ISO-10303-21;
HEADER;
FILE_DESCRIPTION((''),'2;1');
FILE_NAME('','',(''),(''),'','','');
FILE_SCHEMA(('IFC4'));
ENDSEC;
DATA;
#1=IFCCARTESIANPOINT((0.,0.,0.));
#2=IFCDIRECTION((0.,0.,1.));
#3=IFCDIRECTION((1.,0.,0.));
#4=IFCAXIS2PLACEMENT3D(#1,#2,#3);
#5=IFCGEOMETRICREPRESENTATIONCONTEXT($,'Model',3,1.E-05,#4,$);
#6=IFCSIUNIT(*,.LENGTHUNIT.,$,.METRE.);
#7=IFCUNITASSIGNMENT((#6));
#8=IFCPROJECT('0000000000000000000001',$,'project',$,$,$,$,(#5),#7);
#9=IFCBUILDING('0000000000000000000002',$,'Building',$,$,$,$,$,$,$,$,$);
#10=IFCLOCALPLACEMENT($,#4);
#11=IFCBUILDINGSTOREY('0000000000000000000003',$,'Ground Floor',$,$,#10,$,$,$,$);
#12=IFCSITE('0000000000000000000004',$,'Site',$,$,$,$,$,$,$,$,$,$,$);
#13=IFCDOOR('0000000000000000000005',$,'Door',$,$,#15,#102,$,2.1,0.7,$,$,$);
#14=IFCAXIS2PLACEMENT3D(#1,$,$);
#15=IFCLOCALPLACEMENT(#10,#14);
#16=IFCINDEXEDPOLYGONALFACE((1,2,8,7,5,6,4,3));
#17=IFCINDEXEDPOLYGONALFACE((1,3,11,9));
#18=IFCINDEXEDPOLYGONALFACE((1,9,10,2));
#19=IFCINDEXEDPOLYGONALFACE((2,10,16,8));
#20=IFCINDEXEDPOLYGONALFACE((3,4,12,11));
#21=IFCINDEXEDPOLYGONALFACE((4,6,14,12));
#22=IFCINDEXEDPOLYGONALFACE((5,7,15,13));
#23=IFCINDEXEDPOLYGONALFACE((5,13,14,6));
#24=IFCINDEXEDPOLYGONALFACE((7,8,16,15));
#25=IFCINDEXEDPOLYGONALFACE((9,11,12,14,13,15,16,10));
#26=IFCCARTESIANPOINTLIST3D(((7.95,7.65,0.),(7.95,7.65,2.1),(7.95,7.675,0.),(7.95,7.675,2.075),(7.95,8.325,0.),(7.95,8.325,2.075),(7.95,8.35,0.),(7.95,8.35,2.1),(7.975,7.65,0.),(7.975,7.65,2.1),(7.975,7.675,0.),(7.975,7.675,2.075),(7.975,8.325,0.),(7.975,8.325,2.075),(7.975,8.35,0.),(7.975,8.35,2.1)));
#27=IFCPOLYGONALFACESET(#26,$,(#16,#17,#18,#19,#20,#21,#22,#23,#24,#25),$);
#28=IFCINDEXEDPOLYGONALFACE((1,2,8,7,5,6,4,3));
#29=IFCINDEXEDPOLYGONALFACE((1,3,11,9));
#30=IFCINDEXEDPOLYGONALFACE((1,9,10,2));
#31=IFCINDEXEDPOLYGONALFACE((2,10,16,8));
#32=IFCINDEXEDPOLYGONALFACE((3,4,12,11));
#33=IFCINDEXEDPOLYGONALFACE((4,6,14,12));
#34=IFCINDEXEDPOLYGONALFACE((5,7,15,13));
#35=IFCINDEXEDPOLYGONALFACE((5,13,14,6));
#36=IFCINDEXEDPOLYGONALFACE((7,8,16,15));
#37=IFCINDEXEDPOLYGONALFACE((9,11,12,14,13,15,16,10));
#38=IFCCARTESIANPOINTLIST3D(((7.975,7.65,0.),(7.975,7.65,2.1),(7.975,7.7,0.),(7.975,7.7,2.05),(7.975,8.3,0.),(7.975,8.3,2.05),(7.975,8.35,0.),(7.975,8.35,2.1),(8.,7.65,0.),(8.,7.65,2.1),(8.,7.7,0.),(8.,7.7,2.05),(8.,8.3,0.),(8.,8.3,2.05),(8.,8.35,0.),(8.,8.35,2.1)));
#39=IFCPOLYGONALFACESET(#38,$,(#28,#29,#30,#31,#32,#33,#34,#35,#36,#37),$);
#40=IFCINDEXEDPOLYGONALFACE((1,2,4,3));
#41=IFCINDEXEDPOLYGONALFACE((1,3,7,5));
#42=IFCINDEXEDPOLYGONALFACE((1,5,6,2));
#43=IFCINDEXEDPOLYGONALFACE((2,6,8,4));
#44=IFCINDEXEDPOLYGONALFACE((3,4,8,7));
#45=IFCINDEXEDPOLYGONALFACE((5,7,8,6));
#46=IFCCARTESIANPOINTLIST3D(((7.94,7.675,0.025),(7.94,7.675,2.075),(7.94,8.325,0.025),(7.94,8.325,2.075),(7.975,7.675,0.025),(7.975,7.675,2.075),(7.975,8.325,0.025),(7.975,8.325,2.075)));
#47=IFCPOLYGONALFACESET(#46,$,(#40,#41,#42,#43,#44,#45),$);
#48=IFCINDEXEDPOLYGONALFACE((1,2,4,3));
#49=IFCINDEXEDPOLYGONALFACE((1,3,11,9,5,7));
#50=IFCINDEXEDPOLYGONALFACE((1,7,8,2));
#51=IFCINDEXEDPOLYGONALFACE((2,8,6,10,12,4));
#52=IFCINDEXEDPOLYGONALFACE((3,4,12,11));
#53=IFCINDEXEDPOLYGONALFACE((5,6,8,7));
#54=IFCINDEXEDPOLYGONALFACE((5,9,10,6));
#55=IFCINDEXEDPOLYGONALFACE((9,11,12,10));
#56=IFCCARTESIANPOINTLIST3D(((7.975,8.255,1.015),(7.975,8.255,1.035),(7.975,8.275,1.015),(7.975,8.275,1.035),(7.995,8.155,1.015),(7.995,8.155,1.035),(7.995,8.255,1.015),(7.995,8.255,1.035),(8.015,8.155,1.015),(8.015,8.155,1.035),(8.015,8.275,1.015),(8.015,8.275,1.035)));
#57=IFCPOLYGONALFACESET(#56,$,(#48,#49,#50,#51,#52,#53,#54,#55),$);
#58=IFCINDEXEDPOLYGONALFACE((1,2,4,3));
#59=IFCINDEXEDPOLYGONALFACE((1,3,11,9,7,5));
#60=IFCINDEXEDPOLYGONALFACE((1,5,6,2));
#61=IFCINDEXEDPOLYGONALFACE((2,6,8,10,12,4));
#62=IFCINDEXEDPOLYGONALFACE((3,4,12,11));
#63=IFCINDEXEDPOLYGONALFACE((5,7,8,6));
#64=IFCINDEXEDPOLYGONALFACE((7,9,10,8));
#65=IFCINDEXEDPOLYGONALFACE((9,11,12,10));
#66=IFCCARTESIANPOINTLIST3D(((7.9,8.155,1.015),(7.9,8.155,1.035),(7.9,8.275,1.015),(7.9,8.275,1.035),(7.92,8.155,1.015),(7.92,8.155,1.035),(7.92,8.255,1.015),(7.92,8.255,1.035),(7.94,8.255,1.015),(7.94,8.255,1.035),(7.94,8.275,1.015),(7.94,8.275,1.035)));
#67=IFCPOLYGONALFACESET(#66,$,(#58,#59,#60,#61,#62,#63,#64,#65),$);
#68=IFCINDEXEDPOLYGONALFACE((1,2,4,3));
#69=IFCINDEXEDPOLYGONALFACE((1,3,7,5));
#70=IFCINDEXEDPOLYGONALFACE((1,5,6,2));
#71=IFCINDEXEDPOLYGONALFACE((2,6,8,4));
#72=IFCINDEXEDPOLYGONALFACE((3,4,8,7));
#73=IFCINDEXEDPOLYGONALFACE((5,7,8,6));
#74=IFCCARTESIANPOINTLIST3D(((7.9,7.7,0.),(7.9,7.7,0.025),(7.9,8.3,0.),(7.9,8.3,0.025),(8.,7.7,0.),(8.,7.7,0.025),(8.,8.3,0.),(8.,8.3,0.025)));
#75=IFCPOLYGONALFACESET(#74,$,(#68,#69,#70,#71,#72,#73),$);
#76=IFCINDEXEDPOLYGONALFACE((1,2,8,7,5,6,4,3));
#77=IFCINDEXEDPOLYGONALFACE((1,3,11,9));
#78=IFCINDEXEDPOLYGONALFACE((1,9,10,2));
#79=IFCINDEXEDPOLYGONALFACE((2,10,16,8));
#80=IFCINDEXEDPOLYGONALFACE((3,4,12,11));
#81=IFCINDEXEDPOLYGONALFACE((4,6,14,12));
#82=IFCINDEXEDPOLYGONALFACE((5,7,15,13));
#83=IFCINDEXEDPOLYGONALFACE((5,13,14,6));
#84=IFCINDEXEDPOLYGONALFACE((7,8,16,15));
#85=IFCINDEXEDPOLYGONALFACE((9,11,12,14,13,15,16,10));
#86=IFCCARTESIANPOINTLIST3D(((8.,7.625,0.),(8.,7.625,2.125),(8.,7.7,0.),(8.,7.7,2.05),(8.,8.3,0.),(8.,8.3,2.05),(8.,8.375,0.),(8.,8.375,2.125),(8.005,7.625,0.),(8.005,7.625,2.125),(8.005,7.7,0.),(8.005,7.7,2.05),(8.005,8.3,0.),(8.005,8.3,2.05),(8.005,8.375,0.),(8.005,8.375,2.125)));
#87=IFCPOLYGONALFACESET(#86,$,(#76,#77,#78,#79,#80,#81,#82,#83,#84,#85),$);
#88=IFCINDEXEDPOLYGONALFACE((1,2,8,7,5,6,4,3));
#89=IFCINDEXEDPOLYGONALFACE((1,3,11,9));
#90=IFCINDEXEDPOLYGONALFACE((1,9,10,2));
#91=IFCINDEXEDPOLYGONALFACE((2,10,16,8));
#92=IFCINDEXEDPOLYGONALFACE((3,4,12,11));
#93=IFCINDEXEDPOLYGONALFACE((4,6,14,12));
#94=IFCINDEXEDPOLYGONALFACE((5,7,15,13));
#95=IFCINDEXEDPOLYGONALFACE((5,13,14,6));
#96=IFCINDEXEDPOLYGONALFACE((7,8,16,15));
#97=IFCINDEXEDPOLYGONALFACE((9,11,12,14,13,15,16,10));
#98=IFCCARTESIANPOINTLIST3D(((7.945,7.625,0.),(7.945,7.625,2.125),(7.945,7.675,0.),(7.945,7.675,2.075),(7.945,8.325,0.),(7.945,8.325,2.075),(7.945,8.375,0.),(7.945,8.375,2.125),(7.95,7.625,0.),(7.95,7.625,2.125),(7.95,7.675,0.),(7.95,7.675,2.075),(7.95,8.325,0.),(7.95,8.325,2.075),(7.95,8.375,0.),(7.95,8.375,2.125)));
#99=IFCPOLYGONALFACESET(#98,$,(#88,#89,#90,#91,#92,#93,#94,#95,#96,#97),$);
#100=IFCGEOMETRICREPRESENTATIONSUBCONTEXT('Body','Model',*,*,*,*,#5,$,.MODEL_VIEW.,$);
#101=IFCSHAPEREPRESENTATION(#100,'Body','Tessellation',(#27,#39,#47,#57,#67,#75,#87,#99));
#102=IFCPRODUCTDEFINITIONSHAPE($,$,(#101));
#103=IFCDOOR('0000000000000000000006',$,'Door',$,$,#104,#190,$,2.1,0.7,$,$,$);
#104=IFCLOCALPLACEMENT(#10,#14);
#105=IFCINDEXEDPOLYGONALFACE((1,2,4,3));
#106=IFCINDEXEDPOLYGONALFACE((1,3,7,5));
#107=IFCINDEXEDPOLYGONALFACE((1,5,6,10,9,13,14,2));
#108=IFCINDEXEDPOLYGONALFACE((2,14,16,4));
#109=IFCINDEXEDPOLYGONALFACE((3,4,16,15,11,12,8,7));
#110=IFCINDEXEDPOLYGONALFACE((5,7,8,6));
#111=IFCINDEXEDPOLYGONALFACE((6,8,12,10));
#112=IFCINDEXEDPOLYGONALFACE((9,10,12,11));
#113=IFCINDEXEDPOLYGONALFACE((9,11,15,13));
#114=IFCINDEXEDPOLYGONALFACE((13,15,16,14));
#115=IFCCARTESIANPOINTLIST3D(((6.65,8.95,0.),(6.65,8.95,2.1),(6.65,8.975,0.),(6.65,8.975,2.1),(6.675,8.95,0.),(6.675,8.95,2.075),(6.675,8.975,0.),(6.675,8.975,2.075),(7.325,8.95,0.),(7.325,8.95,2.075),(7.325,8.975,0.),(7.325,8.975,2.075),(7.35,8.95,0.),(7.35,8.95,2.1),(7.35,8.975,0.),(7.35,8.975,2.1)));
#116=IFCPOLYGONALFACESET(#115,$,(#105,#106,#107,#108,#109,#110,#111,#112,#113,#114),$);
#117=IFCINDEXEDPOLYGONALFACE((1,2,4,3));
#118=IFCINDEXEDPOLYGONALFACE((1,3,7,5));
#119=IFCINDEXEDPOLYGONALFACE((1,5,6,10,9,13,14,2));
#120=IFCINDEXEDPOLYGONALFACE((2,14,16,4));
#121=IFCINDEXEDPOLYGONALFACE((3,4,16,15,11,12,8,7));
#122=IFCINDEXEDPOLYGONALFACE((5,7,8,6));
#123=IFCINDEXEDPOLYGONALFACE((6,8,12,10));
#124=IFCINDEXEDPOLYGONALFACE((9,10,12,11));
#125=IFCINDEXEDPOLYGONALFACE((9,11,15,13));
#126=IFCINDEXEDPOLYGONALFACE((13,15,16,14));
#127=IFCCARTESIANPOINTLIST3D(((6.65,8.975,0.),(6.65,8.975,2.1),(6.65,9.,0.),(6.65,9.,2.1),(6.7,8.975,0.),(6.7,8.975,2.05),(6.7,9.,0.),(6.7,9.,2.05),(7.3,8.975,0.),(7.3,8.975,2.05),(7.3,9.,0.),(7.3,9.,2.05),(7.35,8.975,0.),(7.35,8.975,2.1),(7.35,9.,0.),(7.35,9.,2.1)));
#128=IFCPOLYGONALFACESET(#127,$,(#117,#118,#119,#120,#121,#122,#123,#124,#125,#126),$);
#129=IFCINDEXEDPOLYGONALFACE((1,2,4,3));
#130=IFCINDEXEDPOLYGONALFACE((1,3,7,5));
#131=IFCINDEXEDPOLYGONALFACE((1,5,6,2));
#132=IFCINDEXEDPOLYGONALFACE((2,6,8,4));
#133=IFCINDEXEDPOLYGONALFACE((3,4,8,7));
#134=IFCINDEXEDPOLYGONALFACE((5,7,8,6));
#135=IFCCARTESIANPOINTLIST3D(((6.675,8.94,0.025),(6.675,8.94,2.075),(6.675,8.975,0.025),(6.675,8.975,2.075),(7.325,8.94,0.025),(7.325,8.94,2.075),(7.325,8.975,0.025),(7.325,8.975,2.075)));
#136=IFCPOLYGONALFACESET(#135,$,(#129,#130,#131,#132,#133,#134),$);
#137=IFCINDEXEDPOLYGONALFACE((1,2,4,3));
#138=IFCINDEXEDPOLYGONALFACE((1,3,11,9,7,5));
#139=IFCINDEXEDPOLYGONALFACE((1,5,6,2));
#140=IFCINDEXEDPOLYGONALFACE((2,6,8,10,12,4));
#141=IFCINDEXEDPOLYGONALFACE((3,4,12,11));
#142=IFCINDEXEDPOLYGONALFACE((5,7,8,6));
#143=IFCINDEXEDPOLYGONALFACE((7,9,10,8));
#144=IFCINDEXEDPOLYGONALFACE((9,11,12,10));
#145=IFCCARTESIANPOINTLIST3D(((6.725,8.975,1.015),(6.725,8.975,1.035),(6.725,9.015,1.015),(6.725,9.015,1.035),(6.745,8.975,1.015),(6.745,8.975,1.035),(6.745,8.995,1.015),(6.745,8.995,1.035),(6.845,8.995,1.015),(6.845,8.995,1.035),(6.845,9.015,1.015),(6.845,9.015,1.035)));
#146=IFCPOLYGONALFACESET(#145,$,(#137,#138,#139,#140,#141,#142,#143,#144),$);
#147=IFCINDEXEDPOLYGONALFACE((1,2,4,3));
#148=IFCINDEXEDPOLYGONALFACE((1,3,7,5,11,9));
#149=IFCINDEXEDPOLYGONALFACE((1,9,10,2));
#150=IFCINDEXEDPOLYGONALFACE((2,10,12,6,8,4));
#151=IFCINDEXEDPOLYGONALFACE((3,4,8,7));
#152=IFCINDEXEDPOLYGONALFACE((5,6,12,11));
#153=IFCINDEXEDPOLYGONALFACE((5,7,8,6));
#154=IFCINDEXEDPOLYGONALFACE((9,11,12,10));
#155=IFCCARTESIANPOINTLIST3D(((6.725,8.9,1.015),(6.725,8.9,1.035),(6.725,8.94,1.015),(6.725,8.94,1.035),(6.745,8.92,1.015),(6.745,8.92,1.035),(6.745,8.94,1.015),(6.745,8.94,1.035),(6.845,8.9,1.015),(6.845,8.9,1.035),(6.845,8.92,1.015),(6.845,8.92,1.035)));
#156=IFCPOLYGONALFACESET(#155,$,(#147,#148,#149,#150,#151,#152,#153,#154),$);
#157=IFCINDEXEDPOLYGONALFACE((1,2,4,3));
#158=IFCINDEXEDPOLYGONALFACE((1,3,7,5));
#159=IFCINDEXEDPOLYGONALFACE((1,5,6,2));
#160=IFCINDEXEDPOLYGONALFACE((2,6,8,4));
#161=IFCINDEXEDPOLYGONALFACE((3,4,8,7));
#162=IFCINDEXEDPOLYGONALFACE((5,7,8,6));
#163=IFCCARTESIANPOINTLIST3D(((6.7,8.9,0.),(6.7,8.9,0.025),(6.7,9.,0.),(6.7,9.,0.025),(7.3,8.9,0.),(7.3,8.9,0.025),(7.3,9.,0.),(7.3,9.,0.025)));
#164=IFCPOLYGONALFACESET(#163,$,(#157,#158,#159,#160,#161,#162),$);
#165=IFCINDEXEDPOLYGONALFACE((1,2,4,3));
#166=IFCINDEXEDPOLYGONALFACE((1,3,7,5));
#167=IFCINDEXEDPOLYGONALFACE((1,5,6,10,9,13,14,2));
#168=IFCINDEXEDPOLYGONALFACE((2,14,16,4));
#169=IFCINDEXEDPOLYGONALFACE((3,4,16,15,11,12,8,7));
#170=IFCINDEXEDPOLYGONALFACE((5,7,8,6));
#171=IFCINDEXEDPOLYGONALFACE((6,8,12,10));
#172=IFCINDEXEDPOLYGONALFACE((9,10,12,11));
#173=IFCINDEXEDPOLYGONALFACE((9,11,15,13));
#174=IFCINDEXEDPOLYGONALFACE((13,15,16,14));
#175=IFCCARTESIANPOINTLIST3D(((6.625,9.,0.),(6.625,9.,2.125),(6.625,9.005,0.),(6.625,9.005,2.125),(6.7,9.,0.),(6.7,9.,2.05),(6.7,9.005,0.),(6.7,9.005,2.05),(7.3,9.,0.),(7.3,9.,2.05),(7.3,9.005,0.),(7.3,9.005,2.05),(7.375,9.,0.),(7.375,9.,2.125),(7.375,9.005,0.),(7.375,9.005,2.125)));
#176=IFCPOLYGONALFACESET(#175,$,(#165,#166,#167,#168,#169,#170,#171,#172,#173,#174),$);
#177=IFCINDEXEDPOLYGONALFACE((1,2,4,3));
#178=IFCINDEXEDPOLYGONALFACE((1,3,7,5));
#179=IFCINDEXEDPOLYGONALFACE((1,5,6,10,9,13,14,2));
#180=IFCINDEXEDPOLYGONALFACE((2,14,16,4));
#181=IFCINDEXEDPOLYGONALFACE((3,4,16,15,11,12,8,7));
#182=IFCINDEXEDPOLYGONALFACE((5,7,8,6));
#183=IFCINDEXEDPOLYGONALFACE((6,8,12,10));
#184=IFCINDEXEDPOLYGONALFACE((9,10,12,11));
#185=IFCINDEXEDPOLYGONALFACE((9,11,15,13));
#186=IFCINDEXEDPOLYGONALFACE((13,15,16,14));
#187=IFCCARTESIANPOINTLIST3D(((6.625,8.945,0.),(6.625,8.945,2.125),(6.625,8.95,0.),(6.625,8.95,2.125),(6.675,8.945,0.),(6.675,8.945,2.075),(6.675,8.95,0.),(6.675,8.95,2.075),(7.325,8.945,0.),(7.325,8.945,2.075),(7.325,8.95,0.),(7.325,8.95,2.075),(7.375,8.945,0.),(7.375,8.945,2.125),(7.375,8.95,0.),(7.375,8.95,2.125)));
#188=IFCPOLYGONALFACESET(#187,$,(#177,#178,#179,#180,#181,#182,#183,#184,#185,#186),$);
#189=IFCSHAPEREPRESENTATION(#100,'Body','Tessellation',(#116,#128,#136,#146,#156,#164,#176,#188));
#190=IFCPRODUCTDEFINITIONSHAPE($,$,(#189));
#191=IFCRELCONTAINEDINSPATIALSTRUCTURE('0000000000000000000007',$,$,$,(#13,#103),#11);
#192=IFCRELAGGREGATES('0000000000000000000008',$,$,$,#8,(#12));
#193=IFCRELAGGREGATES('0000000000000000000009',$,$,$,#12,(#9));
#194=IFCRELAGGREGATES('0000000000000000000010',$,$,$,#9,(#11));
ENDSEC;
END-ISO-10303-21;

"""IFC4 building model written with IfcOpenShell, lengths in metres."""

from ifc_helpers import new_model, si_unit, frame, origin_with_axes, place, context, subcontext, project, spatial, line, indexed_curve, outline, extrude, element, save


model = new_model("IFC4")

# Units and contexts
model_context = context("Model", 3, precision=1e-05, world=origin_with_axes())
body_context = subcontext(model_context, "Body", "Model", "MODEL_VIEW")
ifc_project = project(units=[si_unit("LENGTHUNIT", "METRE")], contexts=[model_context])

# Site, building, storey
site = spatial("IfcSite", under=ifc_project, Name="Site")
building = spatial("IfcBuilding", under=site, Name="Building")
storey_placement = place(None, origin_with_axes())
storey = spatial("IfcBuildingStorey", under=building, at=storey_placement, Name="Ground Floor")

# Doors
door_1_placement = place(storey_placement, frame((8.0, 7.65, 0.0), z_axis=(0.0, 0.0, 1.0), x_axis=(0.0, 1.0, 0.0)))
element("IfcDoor", 1, at=door_1_placement, inside=storey, Name="Door", OverallHeight=2.1, OverallWidth=0.7, context=body_context, shape_type="SweptSolid", body=[
    extrude(outline(indexed_curve([(0.0, 0.0), (0.0, 2.1), (0.7, 2.1), (0.7, 0.0), (0.675, 0.0), (0.675, 2.075), (0.025, 2.075), (0.025, 0.0)], segments=[line(1, 2, 3, 4, 5, 6, 7, 8, 1)])), frame((0.0, 0.025, 0.0), z_axis=(0.0, -1.0, 0.0), x_axis=(1.0, 0.0, 0.0)), (0.0, 0.0, -1.0), 0.025),
    extrude(outline(indexed_curve([(0.0, 0.0), (0.0, 2.1), (0.7, 2.1), (0.7, 0.0), (0.65, 0.0), (0.65, 2.05), (0.05, 2.05), (0.05, 0.0)], segments=[line(1, 2, 3, 4, 5, 6, 7, 8, 1)])), frame((0.0, 0.0, 0.0), z_axis=(0.0, -1.0, 0.0), x_axis=(1.0, 0.0, 0.0)), (0.0, 0.0, -1.0), 0.025),
    extrude(outline(indexed_curve([(0.0, 0.0), (0.65, 0.0), (0.65, 0.035), (0.0, 0.035)], segments=[line(1, 2, 3, 4, 1)])), frame((0.025, 0.025, 0.025), z_axis=(0.0, 0.0, 1.0), x_axis=(1.0, 0.0, 0.0)), (0.0, 0.0, 1.0), 2.05),
    extrude(outline(indexed_curve([(0.0, 0.0), (0.0, -0.04), (-0.12, -0.04), (-0.12, -0.02), (-0.02, -0.02), (-0.02, 0.0)], segments=[line(1, 2, 3, 4, 5, 6, 1)])), frame((0.625, 0.025, 1.015), z_axis=(0.0, 0.0, 1.0), x_axis=(1.0, 0.0, 0.0)), (0.0, 0.0, 1.0), 0.02),
    extrude(outline(indexed_curve([(0.0, 0.0), (0.0, 0.04), (-0.12, 0.04), (-0.12, 0.02), (-0.02, 0.02), (-0.02, 0.0)], segments=[line(1, 2, 3, 4, 5, 6, 1)])), frame((0.625, 0.06, 1.015), z_axis=(0.0, 0.0, 1.0), x_axis=(1.0, 0.0, 0.0)), (0.0, 0.0, 1.0), 0.02),
    extrude(outline(indexed_curve([(0.0, 0.0), (0.6, 0.0), (0.6, 0.1), (0.0, 0.1)], segments=[line(1, 2, 3, 4, 1)])), frame((0.05, 0.0, 0.0), z_axis=(0.0, 0.0, 1.0), x_axis=(1.0, 0.0, 0.0)), (0.0, 0.0, 1.0), 0.025),
    extrude(outline(indexed_curve([(0.0, 0.0), (0.0, 2.125), (0.75, 2.125), (0.75, 0.0), (0.675, 0.0), (0.675, 2.05), (0.075, 2.05), (0.075, 0.0)], segments=[line(1, 2, 3, 4, 5, 6, 7, 8, 1)])), frame((-0.025, -0.005, 0.0), z_axis=(0.0, -1.0, 0.0), x_axis=(1.0, 0.0, 0.0)), (0.0, 0.0, -1.0), 0.005),
    extrude(outline(indexed_curve([(0.0, 0.0), (0.0, 2.125), (0.75, 2.125), (0.75, 0.0), (0.7, 0.0), (0.7, 2.075), (0.05, 2.075), (0.05, 0.0)], segments=[line(1, 2, 3, 4, 5, 6, 7, 8, 1)])), frame((-0.025, 0.05, 0.0), z_axis=(0.0, -1.0, 0.0), x_axis=(1.0, 0.0, 0.0)), (0.0, 0.0, -1.0), 0.005),
])
door_2_placement = place(storey_placement, frame((7.35, 9.0, 0.0), z_axis=(0.0, 0.0, 1.0), x_axis=(-1.0, 0.0, 0.0)))
element("IfcDoor", 2, at=door_2_placement, inside=storey, Name="Door", OverallHeight=2.1, OverallWidth=0.7, context=body_context, shape_type="SweptSolid", body=[
    extrude(outline(indexed_curve([(0.0, 0.0), (0.0, 2.1), (0.7, 2.1), (0.7, 0.0), (0.675, 0.0), (0.675, 2.075), (0.025, 2.075), (0.025, 0.0)], segments=[line(1, 2, 3, 4, 5, 6, 7, 8, 1)])), frame((0.0, 0.025, 0.0), z_axis=(0.0, -1.0, 0.0), x_axis=(1.0, 0.0, 0.0)), (0.0, 0.0, -1.0), 0.025),
    extrude(outline(indexed_curve([(0.0, 0.0), (0.0, 2.1), (0.7, 2.1), (0.7, 0.0), (0.65, 0.0), (0.65, 2.05), (0.05, 2.05), (0.05, 0.0)], segments=[line(1, 2, 3, 4, 5, 6, 7, 8, 1)])), frame((0.0, 0.0, 0.0), z_axis=(0.0, -1.0, 0.0), x_axis=(1.0, 0.0, 0.0)), (0.0, 0.0, -1.0), 0.025),
    extrude(outline(indexed_curve([(0.0, 0.0), (0.65, 0.0), (0.65, 0.035), (0.0, 0.035)], segments=[line(1, 2, 3, 4, 1)])), frame((0.025, 0.025, 0.025), z_axis=(0.0, 0.0, 1.0), x_axis=(1.0, 0.0, 0.0)), (0.0, 0.0, 1.0), 2.05),
    extrude(outline(indexed_curve([(0.0, 0.0), (0.0, -0.04), (-0.12, -0.04), (-0.12, -0.02), (-0.02, -0.02), (-0.02, 0.0)], segments=[line(1, 2, 3, 4, 5, 6, 1)])), frame((0.625, 0.025, 1.015), z_axis=(0.0, 0.0, 1.0), x_axis=(1.0, 0.0, 0.0)), (0.0, 0.0, 1.0), 0.02),
    extrude(outline(indexed_curve([(0.0, 0.0), (0.0, 0.04), (-0.12, 0.04), (-0.12, 0.02), (-0.02, 0.02), (-0.02, 0.0)], segments=[line(1, 2, 3, 4, 5, 6, 1)])), frame((0.625, 0.06, 1.015), z_axis=(0.0, 0.0, 1.0), x_axis=(1.0, 0.0, 0.0)), (0.0, 0.0, 1.0), 0.02),
    extrude(outline(indexed_curve([(0.0, 0.0), (0.6, 0.0), (0.6, 0.1), (0.0, 0.1)], segments=[line(1, 2, 3, 4, 1)])), frame((0.05, 0.0, 0.0), z_axis=(0.0, 0.0, 1.0), x_axis=(1.0, 0.0, 0.0)), (0.0, 0.0, 1.0), 0.025),
    extrude(outline(indexed_curve([(0.0, 0.0), (0.0, 2.125), (0.75, 2.125), (0.75, 0.0), (0.675, 0.0), (0.675, 2.05), (0.075, 2.05), (0.075, 0.0)], segments=[line(1, 2, 3, 4, 5, 6, 7, 8, 1)])), frame((-0.025, -0.005, 0.0), z_axis=(0.0, -1.0, 0.0), x_axis=(1.0, 0.0, 0.0)), (0.0, 0.0, -1.0), 0.005),
    extrude(outline(indexed_curve([(0.0, 0.0), (0.0, 2.125), (0.75, 2.125), (0.75, 0.0), (0.7, 0.0), (0.7, 2.075), (0.05, 2.075), (0.05, 0.0)], segments=[line(1, 2, 3, 4, 5, 6, 7, 8, 1)])), frame((-0.025, 0.05, 0.0), z_axis=(0.0, -1.0, 0.0), x_axis=(1.0, 0.0, 0.0)), (0.0, 0.0, -1.0), 0.005),
])

save(model, "model.ifc")
